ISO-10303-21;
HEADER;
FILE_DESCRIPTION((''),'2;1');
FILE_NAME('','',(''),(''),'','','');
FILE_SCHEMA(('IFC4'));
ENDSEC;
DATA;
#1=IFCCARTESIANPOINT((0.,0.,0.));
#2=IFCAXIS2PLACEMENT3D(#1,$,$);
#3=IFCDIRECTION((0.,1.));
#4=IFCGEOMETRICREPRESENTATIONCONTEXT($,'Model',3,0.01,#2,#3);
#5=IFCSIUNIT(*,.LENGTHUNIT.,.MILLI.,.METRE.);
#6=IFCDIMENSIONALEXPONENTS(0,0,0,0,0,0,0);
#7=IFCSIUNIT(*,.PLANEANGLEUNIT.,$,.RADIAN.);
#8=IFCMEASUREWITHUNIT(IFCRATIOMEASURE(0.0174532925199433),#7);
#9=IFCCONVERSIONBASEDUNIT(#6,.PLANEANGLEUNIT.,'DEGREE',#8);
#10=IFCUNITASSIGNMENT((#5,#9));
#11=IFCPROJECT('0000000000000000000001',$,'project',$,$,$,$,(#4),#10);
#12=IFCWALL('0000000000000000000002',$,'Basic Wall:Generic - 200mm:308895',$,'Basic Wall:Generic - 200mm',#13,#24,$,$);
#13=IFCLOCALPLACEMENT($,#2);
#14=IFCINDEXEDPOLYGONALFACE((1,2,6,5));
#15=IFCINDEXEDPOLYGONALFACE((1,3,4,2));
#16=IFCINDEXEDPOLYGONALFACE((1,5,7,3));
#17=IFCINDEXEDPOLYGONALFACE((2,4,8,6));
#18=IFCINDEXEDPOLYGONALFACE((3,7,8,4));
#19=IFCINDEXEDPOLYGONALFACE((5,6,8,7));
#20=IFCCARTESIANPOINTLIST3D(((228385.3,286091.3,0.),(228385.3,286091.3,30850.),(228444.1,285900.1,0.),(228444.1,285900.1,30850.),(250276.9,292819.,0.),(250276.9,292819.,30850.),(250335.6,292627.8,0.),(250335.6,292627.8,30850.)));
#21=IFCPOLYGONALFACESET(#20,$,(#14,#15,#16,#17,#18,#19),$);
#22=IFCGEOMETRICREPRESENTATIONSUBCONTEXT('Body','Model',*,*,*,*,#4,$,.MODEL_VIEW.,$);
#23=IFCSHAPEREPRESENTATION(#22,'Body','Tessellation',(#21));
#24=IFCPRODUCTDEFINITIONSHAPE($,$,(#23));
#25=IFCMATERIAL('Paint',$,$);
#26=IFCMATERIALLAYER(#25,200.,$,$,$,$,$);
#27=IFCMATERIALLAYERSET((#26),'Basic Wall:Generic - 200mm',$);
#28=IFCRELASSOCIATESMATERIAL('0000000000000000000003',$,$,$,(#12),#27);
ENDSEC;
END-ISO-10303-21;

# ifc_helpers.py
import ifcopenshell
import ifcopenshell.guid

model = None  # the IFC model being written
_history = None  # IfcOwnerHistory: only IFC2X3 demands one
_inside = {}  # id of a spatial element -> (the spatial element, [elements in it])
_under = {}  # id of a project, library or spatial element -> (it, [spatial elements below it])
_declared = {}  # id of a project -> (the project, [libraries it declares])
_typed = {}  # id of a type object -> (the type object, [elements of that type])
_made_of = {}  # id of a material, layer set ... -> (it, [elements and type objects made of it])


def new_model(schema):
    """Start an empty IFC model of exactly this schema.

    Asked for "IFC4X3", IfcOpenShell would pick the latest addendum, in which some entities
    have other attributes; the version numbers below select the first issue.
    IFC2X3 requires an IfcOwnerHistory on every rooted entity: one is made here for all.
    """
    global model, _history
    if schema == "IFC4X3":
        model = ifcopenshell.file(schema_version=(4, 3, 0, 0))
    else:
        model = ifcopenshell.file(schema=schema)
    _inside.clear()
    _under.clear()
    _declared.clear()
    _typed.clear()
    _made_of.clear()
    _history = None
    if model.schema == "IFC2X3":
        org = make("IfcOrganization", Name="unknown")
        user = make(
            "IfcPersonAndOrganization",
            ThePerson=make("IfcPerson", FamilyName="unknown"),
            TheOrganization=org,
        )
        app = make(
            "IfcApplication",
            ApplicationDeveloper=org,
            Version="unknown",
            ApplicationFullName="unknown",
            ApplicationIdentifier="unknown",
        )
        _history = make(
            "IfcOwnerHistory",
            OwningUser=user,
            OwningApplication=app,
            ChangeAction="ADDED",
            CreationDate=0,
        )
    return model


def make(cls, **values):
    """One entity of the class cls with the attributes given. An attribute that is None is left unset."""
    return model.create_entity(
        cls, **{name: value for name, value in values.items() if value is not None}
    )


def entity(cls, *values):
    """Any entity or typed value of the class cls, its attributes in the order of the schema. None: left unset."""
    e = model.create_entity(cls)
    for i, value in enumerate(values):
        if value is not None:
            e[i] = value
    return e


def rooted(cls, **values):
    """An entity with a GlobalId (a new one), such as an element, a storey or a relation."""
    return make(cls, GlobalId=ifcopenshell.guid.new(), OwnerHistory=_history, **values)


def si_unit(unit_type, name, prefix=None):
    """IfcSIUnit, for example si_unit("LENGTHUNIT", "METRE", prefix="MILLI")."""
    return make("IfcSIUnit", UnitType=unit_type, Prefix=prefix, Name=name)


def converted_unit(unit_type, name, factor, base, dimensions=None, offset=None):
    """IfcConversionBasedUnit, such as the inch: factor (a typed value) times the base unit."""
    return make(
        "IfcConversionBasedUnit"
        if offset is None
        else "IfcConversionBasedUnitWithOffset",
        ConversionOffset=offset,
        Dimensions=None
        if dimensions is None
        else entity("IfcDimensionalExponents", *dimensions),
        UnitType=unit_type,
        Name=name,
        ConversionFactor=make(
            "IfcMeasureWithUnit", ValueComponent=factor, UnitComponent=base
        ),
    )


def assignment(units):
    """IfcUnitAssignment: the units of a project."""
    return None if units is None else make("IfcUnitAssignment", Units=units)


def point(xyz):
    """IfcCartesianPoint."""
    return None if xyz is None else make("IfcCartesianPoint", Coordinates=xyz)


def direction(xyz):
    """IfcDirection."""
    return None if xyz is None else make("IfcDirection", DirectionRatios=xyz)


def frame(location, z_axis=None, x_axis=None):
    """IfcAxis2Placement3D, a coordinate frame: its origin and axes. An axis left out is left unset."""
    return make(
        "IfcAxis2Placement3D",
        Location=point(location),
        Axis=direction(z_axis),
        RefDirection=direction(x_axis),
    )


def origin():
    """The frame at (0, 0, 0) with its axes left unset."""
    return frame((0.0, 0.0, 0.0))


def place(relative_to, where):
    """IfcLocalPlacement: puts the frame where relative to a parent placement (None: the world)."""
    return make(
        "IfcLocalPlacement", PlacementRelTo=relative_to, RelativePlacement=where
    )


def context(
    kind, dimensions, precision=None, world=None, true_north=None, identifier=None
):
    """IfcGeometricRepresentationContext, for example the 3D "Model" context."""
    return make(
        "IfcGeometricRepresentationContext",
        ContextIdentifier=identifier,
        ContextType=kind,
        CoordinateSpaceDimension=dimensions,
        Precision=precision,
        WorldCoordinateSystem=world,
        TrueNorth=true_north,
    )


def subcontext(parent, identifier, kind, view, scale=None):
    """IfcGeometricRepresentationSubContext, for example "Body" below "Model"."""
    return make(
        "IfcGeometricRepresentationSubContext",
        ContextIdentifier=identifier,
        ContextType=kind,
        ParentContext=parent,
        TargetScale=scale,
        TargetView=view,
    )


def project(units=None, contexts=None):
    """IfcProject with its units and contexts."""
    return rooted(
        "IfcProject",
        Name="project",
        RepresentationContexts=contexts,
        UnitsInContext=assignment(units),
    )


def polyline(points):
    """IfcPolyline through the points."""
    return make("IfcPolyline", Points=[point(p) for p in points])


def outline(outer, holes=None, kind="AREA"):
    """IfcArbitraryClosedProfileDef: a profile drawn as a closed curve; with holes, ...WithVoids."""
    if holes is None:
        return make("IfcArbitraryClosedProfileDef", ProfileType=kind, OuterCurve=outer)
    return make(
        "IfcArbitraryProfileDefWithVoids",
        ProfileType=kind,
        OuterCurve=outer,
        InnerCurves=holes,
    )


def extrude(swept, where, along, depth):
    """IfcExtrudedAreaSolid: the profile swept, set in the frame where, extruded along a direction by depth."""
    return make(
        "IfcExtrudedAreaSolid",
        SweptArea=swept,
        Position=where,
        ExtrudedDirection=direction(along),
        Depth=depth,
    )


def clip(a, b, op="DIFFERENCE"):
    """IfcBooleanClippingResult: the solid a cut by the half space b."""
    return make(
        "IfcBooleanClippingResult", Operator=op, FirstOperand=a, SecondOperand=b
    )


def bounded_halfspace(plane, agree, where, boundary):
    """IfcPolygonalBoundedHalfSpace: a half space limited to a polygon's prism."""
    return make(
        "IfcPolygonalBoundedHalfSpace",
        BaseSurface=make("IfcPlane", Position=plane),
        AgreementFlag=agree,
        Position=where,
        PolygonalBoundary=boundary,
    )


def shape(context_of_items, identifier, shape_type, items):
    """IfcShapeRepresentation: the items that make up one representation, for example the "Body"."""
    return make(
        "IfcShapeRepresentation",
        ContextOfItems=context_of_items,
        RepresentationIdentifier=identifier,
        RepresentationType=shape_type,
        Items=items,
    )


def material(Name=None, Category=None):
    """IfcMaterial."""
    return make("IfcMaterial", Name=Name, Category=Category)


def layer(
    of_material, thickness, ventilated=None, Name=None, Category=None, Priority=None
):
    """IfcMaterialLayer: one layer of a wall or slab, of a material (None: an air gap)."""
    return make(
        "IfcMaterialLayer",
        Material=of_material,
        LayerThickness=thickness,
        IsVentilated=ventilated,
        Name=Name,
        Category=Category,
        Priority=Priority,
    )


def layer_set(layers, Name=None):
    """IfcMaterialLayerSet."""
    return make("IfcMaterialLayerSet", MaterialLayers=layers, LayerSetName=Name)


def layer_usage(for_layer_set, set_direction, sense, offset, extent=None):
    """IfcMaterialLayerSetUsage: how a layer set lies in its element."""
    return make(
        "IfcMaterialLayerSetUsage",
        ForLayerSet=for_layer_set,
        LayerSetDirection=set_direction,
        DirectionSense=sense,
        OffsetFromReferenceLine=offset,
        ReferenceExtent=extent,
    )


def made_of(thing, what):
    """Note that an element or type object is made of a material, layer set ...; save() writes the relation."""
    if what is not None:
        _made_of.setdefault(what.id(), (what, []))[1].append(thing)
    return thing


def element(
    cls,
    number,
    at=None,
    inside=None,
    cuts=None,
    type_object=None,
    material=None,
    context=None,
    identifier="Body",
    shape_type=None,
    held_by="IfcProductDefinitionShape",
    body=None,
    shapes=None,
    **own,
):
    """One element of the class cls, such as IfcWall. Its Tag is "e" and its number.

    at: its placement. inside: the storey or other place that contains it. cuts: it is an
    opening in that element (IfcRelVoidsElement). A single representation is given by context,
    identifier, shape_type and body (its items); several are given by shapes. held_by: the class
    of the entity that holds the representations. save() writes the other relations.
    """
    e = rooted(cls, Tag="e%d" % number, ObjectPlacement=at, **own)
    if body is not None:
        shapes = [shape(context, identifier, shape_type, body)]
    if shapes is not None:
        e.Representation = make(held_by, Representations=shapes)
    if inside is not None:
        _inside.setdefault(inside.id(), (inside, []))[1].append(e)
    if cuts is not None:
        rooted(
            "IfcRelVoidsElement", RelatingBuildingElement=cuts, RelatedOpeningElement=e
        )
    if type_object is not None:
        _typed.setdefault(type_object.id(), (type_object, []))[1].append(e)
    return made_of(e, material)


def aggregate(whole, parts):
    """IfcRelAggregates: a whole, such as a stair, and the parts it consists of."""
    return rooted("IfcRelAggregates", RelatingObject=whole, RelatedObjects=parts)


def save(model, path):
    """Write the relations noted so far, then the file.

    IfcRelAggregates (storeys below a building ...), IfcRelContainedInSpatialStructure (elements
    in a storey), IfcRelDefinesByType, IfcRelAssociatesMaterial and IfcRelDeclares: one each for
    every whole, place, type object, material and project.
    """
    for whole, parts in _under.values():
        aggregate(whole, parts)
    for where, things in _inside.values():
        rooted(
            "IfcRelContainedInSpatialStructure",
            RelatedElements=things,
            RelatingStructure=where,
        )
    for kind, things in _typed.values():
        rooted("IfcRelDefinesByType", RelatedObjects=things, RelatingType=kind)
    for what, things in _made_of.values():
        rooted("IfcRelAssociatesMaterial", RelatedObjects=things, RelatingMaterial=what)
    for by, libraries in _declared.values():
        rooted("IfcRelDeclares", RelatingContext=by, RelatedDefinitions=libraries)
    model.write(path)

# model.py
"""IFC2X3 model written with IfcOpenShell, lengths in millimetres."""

from ifc_helpers import new_model, entity, si_unit, converted_unit, direction, frame, origin, place, context, subcontext, project, polyline, outline, extrude, clip, bounded_halfspace, material, layer, layer_set, layer_usage, element, save


model = new_model("IFC2X3")

# Units and contexts
model_context = context("Model", 3, precision=0.01, world=origin(), true_north=direction((0.0, 1.0)))
body_context = subcontext(model_context, "Body", "Model", "MODEL_VIEW")
ifc_project = project(units=[si_unit("LENGTHUNIT", "METRE", prefix="MILLI"), converted_unit("PLANEANGLEUNIT", "DEGREE", entity("IfcRatioMeasure", 0.0174532925199433), si_unit("PLANEANGLEUNIT", "RADIAN"), dimensions=[0, 0, 0, 0, 0, 0, 0])], contexts=[model_context])

# Wall
ifc_material = material(Name="Paint")
ifc_layer = layer(ifc_material, 200.0)
ifc_layer_set = layer_set([ifc_layer], Name="Basic Wall:Generic - 200mm")
ifc_layer_usage = layer_usage(ifc_layer_set, "AXIS2", "NEGATIVE", 100.0)
placement_1 = place(None, origin())
placement_2 = place(placement_1, origin())
placement_3 = place(placement_2, origin())
wall_placement = place(placement_3, frame((228414.7, 285995.7, 0.0), z_axis=(0.0, 0.0, 1.0), x_axis=(0.95588, 0.293758, 0.0)))
element("IfcWall", 1, at=wall_placement, material=ifc_layer_usage, Name="Basic Wall:Generic - 200mm:308895", ObjectType="Basic Wall:Generic - 200mm", context=body_context, shape_type="Clipping", body=[
    clip(extrude(outline(polyline([(22902.0, -100.0), (22902.0, 100.0), (0.0, 100.0), (0.0, -100.0), (200.0, -100.0), (22702.0, -100.0), (22902.0, -100.0)])), origin(), (0.0, 0.0, 1.0), 30850.0), bounded_halfspace(frame((0.0, -100.0, 30850.0), z_axis=(0.0, 0.0, -1.0), x_axis=(-1.0, 0.0, 0.0)), True, frame((0.0, -100.0, 30850.0), z_axis=(0.0, 0.0, -1.0), x_axis=(-1.0, 0.0, 0.0)), polyline([(0.0, 0.0), (0.0, 200.0), (-22902.0, 200.0), (-22902.0, 0.0), (-22702.0, 0.0), (-200.0, 0.0), (0.0, 0.0)]))),
])

save(model, "model.ifc")
